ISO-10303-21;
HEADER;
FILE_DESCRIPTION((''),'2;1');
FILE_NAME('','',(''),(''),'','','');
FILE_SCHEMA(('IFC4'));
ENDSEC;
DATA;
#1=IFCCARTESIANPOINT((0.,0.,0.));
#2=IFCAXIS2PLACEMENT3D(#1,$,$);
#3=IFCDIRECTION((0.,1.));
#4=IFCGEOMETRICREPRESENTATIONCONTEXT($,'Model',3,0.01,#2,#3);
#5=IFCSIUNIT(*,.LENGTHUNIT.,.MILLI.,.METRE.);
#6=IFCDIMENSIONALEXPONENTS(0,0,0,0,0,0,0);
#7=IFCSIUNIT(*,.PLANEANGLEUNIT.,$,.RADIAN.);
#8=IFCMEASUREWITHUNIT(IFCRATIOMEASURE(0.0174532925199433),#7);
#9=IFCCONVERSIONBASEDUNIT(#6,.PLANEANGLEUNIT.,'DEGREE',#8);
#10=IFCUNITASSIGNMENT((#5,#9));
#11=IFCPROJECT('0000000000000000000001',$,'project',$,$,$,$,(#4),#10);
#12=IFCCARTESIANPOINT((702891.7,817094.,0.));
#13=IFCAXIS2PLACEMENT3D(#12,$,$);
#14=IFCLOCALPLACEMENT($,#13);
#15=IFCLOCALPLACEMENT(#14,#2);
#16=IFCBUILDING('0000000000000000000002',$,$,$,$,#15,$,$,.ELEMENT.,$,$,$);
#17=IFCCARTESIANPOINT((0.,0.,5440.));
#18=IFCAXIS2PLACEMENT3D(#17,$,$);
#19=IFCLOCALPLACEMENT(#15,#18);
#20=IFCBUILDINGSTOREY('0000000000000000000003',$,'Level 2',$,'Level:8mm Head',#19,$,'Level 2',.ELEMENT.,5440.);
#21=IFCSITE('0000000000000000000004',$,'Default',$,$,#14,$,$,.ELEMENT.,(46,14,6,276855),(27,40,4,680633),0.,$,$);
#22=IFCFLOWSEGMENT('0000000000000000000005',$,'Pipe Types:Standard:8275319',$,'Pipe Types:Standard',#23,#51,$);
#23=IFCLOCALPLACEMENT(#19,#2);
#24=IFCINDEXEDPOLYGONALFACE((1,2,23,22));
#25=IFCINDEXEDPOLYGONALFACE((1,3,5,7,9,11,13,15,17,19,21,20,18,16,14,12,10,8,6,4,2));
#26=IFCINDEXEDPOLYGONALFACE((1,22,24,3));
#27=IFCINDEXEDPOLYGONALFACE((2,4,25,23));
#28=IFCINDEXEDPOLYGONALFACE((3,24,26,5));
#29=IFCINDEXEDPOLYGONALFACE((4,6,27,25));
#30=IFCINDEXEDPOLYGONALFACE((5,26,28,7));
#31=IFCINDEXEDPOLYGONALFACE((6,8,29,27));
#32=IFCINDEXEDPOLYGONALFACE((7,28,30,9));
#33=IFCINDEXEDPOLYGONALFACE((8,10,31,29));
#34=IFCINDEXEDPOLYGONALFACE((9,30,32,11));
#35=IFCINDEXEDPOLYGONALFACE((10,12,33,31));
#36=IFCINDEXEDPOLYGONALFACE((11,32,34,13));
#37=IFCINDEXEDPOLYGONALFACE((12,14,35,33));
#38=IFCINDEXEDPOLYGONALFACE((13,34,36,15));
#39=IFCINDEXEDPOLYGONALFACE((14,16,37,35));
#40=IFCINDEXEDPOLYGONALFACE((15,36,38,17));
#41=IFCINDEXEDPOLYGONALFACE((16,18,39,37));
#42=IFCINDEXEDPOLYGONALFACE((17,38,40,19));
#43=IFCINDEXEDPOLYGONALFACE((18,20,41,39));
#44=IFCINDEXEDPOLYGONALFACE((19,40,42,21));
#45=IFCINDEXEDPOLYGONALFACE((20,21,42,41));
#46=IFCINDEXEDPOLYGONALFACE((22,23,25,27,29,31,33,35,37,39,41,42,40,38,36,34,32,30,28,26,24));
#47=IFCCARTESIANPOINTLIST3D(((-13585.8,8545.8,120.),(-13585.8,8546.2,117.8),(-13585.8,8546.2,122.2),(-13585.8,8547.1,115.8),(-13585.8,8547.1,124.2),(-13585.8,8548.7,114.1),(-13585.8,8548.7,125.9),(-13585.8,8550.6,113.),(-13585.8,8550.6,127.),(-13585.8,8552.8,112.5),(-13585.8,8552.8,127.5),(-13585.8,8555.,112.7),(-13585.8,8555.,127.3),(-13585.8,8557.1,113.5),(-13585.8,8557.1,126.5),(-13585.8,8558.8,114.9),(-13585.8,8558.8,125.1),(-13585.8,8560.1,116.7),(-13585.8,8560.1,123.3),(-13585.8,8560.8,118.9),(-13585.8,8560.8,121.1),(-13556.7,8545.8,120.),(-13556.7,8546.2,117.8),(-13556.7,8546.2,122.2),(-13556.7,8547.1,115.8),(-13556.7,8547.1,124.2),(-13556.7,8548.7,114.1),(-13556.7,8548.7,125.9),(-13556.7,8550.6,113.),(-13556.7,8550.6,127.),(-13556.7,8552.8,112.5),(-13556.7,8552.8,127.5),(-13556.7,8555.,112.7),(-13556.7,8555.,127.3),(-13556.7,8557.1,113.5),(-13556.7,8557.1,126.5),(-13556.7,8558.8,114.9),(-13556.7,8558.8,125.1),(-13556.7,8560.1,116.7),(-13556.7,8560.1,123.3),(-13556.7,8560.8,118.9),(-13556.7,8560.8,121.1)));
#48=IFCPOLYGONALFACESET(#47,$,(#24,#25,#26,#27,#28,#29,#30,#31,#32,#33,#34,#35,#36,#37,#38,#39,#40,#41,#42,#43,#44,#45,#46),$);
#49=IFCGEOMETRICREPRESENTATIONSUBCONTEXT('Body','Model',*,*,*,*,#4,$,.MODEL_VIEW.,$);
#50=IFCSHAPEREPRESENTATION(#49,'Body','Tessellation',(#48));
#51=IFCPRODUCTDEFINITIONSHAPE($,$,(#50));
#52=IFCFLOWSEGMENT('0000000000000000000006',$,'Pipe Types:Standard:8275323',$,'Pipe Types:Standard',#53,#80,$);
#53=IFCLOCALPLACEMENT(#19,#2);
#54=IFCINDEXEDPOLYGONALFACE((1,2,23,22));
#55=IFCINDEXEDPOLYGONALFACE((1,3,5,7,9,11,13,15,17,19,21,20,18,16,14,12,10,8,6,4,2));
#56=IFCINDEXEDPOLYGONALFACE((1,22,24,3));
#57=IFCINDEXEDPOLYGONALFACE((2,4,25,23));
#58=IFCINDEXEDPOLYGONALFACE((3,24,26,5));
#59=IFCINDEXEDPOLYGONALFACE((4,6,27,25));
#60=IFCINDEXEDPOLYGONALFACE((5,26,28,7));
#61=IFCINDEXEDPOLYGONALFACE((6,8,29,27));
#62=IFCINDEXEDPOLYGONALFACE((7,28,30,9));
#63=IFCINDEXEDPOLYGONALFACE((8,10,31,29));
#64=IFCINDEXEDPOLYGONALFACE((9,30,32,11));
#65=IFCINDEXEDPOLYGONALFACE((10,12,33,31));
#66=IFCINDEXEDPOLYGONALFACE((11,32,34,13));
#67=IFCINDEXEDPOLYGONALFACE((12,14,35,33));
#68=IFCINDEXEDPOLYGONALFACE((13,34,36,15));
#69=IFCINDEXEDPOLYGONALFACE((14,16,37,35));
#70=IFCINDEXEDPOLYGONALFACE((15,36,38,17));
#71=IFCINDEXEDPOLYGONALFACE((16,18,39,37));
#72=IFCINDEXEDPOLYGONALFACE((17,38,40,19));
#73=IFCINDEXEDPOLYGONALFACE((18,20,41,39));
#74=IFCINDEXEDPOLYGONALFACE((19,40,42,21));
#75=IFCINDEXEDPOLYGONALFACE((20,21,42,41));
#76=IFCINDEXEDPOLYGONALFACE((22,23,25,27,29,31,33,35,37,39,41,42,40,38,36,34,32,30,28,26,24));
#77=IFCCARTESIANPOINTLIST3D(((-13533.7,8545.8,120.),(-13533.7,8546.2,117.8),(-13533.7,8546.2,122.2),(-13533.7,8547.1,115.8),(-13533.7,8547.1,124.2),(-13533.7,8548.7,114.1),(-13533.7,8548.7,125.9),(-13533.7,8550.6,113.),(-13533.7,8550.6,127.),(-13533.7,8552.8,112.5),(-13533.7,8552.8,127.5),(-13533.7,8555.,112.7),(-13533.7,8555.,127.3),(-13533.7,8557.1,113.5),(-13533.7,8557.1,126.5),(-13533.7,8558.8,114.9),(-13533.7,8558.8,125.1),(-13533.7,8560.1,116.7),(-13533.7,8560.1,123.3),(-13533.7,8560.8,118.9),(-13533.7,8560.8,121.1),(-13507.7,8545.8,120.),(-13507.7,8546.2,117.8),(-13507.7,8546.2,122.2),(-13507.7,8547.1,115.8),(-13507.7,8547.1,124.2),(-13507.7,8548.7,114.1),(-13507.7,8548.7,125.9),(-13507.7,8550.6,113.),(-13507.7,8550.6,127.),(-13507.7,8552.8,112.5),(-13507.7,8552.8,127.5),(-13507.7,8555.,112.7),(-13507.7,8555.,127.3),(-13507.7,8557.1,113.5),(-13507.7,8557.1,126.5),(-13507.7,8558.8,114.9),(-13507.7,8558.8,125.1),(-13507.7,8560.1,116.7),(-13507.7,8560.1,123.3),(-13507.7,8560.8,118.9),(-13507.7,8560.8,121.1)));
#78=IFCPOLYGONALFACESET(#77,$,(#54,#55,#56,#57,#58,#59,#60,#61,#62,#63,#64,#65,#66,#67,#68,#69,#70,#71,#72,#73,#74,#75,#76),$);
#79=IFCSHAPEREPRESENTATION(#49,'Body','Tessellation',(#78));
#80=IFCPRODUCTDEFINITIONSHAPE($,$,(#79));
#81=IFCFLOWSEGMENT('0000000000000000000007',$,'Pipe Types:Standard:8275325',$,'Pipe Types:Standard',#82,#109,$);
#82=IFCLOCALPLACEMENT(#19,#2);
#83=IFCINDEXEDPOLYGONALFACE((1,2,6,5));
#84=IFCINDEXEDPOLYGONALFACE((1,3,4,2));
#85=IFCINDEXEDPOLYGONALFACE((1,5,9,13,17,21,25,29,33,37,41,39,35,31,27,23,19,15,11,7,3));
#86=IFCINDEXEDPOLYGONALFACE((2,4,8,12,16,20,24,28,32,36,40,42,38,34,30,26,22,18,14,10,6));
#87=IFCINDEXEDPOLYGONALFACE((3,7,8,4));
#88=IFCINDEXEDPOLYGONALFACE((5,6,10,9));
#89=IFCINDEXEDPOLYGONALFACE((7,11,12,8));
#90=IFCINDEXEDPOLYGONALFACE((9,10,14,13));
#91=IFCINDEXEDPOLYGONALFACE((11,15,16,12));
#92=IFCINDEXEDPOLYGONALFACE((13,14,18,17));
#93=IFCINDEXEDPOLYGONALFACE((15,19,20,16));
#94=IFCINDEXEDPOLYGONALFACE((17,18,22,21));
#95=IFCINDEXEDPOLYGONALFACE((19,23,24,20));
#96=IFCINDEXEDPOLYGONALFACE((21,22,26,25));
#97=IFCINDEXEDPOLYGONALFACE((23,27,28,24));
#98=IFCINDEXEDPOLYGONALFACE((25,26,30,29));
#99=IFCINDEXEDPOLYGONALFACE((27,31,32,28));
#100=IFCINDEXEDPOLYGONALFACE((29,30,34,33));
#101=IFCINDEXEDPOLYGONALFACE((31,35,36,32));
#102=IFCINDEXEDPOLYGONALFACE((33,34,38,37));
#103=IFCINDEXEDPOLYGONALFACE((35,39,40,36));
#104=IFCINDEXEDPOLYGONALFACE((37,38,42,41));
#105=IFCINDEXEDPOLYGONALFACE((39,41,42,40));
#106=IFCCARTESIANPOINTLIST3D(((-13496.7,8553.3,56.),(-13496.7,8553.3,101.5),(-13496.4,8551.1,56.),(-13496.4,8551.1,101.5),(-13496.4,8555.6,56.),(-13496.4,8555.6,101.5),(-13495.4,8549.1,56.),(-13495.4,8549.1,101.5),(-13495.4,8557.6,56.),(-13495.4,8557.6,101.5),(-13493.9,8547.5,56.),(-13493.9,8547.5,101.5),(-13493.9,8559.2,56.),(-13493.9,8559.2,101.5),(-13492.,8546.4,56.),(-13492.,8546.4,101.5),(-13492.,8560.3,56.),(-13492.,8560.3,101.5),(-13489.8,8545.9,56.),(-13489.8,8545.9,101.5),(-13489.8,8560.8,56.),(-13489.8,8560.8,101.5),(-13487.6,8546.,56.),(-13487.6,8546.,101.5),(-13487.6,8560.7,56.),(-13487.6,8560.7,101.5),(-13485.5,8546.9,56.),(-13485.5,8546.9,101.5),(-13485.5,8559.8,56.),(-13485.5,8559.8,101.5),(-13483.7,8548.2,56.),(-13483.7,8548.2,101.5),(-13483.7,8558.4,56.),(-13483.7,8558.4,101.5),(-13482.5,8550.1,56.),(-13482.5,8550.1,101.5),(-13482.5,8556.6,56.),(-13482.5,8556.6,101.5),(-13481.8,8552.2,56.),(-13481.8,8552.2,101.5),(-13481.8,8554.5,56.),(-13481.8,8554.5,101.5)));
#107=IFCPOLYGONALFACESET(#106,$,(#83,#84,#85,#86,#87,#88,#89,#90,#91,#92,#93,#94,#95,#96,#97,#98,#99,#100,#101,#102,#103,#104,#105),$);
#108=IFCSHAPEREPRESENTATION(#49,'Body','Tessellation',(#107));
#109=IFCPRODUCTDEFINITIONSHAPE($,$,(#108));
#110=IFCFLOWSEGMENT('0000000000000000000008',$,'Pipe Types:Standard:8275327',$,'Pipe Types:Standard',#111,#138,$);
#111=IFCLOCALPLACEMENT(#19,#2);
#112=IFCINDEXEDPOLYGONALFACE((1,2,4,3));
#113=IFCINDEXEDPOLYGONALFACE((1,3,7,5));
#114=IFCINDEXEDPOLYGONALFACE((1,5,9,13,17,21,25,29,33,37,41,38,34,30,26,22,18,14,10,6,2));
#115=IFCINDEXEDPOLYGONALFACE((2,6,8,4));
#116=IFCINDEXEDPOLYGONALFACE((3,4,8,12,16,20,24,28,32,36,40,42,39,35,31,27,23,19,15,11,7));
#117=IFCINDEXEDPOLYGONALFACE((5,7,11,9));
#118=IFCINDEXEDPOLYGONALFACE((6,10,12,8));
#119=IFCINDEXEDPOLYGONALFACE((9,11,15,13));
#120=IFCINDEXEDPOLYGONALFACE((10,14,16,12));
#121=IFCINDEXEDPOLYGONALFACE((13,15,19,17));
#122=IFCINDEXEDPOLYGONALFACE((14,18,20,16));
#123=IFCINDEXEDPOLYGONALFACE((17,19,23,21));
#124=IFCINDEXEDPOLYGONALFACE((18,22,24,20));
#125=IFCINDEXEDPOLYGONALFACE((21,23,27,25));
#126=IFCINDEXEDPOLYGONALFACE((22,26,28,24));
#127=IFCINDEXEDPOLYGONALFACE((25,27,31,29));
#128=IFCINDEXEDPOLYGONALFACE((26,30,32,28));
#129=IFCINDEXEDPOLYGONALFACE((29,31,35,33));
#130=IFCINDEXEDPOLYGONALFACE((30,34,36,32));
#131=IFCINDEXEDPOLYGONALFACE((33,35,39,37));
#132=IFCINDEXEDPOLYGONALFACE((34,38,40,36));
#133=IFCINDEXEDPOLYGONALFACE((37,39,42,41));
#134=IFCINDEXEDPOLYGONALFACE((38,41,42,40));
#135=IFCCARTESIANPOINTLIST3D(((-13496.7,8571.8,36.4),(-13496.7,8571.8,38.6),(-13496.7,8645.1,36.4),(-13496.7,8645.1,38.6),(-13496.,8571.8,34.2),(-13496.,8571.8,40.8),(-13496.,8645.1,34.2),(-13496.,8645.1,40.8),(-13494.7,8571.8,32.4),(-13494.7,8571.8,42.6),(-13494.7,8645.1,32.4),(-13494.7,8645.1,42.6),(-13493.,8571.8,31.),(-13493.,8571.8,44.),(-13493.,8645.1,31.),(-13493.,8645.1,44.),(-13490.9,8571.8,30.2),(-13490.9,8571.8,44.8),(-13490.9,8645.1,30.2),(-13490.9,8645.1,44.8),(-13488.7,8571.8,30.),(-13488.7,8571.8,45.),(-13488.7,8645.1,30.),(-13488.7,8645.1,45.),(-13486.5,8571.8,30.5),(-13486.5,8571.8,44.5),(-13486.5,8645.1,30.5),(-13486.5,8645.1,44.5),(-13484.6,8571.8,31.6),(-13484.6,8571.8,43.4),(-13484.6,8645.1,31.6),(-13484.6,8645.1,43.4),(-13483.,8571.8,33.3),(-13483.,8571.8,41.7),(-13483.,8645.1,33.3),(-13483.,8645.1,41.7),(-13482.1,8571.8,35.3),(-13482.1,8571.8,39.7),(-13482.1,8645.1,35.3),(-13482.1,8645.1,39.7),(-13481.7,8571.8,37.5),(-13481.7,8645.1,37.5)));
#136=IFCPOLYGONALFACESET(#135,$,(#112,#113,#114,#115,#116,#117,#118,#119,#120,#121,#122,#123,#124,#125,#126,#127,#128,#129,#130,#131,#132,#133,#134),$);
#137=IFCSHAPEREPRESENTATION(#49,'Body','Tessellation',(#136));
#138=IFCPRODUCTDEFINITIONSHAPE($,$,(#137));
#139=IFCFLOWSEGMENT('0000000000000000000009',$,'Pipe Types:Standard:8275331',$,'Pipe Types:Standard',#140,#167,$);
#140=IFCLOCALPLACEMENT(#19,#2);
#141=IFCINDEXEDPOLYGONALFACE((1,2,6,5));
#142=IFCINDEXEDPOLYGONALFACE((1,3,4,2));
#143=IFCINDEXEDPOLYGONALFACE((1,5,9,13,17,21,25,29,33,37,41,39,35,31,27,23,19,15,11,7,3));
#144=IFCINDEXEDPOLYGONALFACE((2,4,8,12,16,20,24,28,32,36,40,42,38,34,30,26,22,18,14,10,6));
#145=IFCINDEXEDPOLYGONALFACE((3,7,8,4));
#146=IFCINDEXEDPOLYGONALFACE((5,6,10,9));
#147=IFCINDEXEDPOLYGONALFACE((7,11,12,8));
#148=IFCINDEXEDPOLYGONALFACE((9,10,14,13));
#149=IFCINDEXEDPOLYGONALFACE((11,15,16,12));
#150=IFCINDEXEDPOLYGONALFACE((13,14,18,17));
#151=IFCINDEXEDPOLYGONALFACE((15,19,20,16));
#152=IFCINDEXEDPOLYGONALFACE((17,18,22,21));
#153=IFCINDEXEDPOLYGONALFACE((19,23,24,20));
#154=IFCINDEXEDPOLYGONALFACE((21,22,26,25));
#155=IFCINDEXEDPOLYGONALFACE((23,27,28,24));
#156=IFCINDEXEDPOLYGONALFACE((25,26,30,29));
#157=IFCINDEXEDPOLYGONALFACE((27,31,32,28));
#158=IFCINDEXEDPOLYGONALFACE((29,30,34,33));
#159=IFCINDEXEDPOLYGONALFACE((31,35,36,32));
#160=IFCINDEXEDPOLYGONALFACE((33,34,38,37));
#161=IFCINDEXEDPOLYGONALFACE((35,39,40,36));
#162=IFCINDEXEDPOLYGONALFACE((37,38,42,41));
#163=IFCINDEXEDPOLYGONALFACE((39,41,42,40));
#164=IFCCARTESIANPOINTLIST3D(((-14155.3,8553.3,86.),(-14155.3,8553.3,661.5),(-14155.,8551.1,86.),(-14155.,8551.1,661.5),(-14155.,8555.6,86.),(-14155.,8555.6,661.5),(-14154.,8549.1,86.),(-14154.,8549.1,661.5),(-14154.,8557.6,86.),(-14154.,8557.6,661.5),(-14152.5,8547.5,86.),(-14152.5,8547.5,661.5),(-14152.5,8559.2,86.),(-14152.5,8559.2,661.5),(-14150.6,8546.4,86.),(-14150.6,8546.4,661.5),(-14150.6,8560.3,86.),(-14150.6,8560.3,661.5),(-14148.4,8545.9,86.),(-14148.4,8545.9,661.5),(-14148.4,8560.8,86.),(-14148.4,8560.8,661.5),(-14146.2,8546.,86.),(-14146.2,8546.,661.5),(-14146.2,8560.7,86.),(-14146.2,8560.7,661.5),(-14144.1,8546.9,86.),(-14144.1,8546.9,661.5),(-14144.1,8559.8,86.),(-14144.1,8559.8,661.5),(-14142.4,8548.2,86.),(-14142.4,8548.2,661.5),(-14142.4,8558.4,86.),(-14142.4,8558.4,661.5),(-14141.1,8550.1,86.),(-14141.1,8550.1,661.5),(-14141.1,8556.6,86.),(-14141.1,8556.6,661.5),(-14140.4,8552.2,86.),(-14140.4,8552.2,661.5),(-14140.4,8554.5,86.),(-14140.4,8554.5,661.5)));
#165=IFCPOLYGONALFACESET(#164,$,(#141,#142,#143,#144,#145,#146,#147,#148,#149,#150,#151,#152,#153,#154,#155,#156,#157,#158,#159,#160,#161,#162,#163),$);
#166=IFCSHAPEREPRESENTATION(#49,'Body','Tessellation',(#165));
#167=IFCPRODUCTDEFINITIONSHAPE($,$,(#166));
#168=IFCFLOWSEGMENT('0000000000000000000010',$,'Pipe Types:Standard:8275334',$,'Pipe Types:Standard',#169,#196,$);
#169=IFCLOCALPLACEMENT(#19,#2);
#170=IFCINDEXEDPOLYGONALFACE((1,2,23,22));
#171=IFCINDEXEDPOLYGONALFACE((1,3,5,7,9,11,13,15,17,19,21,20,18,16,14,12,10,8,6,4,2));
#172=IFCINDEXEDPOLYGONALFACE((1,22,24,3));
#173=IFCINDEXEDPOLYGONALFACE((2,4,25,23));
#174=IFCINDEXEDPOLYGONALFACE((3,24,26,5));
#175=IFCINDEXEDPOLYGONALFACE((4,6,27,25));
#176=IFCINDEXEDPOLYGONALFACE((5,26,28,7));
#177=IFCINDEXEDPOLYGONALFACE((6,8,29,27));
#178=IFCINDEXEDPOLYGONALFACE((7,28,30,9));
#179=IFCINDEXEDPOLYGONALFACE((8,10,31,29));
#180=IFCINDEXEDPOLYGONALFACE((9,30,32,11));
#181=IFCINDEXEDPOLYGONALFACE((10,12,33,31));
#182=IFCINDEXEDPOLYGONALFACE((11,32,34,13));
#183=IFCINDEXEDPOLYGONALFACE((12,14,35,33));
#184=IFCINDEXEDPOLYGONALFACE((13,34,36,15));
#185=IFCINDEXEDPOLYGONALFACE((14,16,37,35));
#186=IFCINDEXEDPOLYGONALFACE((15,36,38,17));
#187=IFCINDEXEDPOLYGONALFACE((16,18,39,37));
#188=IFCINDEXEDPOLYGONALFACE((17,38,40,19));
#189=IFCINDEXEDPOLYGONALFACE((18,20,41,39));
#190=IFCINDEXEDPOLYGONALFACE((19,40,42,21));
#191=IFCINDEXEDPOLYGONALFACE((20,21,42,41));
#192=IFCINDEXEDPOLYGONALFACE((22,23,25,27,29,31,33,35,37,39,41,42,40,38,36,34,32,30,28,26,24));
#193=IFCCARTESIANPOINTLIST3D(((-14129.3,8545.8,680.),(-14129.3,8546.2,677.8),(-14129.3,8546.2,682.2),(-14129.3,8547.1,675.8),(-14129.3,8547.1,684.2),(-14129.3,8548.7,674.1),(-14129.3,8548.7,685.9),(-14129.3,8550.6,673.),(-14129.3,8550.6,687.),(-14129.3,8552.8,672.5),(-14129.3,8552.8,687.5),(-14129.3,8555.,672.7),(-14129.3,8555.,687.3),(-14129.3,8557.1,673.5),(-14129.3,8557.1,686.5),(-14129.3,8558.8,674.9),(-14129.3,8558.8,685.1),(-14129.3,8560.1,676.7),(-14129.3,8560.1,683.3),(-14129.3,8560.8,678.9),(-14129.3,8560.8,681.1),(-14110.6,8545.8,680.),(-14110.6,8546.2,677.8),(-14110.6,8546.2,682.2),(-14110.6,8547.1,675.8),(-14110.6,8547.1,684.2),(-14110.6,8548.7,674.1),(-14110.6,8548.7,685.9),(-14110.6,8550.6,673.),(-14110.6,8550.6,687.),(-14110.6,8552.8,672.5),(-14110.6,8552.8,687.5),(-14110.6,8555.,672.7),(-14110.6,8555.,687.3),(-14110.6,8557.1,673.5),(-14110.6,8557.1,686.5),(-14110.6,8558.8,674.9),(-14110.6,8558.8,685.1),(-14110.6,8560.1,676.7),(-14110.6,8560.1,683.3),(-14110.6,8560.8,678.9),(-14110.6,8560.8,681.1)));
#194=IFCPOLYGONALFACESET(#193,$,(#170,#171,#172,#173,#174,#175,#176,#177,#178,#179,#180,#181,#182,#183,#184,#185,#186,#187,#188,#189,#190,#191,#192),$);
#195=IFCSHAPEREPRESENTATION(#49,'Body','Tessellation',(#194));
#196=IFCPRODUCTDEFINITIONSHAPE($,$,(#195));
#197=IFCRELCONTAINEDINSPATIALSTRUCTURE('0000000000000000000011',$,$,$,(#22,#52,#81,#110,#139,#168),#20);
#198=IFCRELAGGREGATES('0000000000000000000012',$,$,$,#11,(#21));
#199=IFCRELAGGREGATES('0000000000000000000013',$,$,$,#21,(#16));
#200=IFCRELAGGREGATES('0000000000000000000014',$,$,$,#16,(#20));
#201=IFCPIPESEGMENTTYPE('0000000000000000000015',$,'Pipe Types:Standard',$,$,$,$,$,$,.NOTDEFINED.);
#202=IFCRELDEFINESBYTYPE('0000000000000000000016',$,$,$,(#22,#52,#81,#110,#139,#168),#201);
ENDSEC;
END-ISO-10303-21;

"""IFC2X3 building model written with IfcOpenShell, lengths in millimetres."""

from ifc_helpers import new_model, entity, si_unit, converted_unit, direction, frame, frame_2d, origin, origin_2d_with_axis, place, context, subcontext, project, spatial, circle, extrude, type_object, element, save


model = new_model("IFC2X3")

# Units and contexts
model_context = context("Model", 3, precision=0.01, world=origin(), true_north=direction((0.0, 1.0)))
body_context = subcontext(model_context, "Body", "Model", "MODEL_VIEW")
ifc_project = project(units=[si_unit("LENGTHUNIT", "METRE", prefix="MILLI"), converted_unit("PLANEANGLEUNIT", "DEGREE", entity("IfcRatioMeasure", 0.0174532925199433), si_unit("PLANEANGLEUNIT", "RADIAN"), dimensions=[0, 0, 0, 0, 0, 0, 0])], contexts=[model_context])

# Site, building, storey
site_placement = place(None, frame((702891.7, 817094.0, 0.0)))
site = spatial("IfcSite", under=ifc_project, at=site_placement, Name="Default", CompositionType="ELEMENT", RefLatitude=(46, 14, 6, 276855), RefLongitude=(27, 40, 4, 680633), RefElevation=0.0)
building_placement = place(site_placement, origin())
building = spatial("IfcBuilding", under=site, at=building_placement, CompositionType="ELEMENT")
storey_placement = place(building_placement, frame((0.0, 0.0, 5440.0)))
storey = spatial("IfcBuildingStorey", under=building, at=storey_placement, Name="Level 2", ObjectType="Level:8mm Head", LongName="Level 2", CompositionType="ELEMENT", Elevation=5440.0)

# Flow segments
pipe_segment_type = type_object("IfcPipeSegmentType", Name="Pipe Types:Standard", PredefinedType="NOTDEFINED")
flow_segment_1_placement = place(storey_placement, origin())
element("IfcFlowSegment", 1, at=flow_segment_1_placement, inside=storey, type_object=pipe_segment_type, Name="Pipe Types:Standard:8275319", ObjectType="Pipe Types:Standard", context=body_context, shape_type="SweptSolid", body=[
    extrude(circle(Radius=7.5, at=frame_2d((0.0, 0.0), x_axis=(1.0, 0.0))), frame((-13585.8, 8553.3, 120.0), z_axis=(1.0, 0.000037, 0.0), x_axis=(0.000037, -1.0, 0.0)), (0.0, 0.0, 1.0), 29.2),
])
flow_segment_2_placement = place(storey_placement, origin())
element("IfcFlowSegment", 2, at=flow_segment_2_placement, inside=storey, type_object=pipe_segment_type, Name="Pipe Types:Standard:8275323", ObjectType="Pipe Types:Standard", context=body_context, shape_type="SweptSolid", body=[
    extrude(circle(Radius=7.5, at=origin_2d_with_axis()), frame((-13533.7, 8553.3, 120.0), z_axis=(1.0, 0.000042, 0.0), x_axis=(0.000042, -1.0, 0.0)), (0.0, 0.0, 1.0), 25.9),
])
flow_segment_3_placement = place(storey_placement, origin())
element("IfcFlowSegment", 3, at=flow_segment_3_placement, inside=storey, type_object=pipe_segment_type, Name="Pipe Types:Standard:8275325", ObjectType="Pipe Types:Standard", context=body_context, shape_type="SweptSolid", body=[
    extrude(circle(Radius=7.5, at=origin_2d_with_axis()), frame((-13489.2, 8553.3, 56.0), z_axis=(0.0, 0.0, 1.0), x_axis=(-1.0, 0.0, 0.0)), (0.0, 0.0, 1.0), 45.5),
])
flow_segment_4_placement = place(storey_placement, origin())
element("IfcFlowSegment", 4, at=flow_segment_4_placement, inside=storey, type_object=pipe_segment_type, Name="Pipe Types:Standard:8275327", ObjectType="Pipe Types:Standard", context=body_context, shape_type="SweptSolid", body=[
    extrude(circle(Radius=7.5, at=origin_2d_with_axis()), frame((-13489.2, 8571.8, 37.5), z_axis=(0.0, 1.0, 0.0), x_axis=(1.0, 0.0, 0.0)), (0.0, 0.0, 1.0), 73.3),
])
flow_segment_5_placement = place(storey_placement, origin())
element("IfcFlowSegment", 5, at=flow_segment_5_placement, inside=storey, type_object=pipe_segment_type, Name="Pipe Types:Standard:8275331", ObjectType="Pipe Types:Standard", context=body_context, shape_type="SweptSolid", body=[
    extrude(circle(Radius=7.5, at=origin_2d_with_axis()), frame((-14147.8, 8553.3, 86.0), z_axis=(0.0, 0.0, 1.0), x_axis=(-1.0, 0.0, 0.0)), (0.0, 0.0, 1.0), 575.5),
])
flow_segment_6_placement = place(storey_placement, origin())
element("IfcFlowSegment", 6, at=flow_segment_6_placement, inside=storey, type_object=pipe_segment_type, Name="Pipe Types:Standard:8275334", ObjectType="Pipe Types:Standard", context=body_context, shape_type="SweptSolid", body=[
    extrude(circle(Radius=7.5, at=origin_2d_with_axis()), frame((-14129.3, 8553.3, 680.0), z_axis=(1.0, 0.0, 0.0), x_axis=(0.0, -1.0, 0.0)), (0.0, 0.0, 1.0), 18.7),
])

save(model, "model.ifc")
